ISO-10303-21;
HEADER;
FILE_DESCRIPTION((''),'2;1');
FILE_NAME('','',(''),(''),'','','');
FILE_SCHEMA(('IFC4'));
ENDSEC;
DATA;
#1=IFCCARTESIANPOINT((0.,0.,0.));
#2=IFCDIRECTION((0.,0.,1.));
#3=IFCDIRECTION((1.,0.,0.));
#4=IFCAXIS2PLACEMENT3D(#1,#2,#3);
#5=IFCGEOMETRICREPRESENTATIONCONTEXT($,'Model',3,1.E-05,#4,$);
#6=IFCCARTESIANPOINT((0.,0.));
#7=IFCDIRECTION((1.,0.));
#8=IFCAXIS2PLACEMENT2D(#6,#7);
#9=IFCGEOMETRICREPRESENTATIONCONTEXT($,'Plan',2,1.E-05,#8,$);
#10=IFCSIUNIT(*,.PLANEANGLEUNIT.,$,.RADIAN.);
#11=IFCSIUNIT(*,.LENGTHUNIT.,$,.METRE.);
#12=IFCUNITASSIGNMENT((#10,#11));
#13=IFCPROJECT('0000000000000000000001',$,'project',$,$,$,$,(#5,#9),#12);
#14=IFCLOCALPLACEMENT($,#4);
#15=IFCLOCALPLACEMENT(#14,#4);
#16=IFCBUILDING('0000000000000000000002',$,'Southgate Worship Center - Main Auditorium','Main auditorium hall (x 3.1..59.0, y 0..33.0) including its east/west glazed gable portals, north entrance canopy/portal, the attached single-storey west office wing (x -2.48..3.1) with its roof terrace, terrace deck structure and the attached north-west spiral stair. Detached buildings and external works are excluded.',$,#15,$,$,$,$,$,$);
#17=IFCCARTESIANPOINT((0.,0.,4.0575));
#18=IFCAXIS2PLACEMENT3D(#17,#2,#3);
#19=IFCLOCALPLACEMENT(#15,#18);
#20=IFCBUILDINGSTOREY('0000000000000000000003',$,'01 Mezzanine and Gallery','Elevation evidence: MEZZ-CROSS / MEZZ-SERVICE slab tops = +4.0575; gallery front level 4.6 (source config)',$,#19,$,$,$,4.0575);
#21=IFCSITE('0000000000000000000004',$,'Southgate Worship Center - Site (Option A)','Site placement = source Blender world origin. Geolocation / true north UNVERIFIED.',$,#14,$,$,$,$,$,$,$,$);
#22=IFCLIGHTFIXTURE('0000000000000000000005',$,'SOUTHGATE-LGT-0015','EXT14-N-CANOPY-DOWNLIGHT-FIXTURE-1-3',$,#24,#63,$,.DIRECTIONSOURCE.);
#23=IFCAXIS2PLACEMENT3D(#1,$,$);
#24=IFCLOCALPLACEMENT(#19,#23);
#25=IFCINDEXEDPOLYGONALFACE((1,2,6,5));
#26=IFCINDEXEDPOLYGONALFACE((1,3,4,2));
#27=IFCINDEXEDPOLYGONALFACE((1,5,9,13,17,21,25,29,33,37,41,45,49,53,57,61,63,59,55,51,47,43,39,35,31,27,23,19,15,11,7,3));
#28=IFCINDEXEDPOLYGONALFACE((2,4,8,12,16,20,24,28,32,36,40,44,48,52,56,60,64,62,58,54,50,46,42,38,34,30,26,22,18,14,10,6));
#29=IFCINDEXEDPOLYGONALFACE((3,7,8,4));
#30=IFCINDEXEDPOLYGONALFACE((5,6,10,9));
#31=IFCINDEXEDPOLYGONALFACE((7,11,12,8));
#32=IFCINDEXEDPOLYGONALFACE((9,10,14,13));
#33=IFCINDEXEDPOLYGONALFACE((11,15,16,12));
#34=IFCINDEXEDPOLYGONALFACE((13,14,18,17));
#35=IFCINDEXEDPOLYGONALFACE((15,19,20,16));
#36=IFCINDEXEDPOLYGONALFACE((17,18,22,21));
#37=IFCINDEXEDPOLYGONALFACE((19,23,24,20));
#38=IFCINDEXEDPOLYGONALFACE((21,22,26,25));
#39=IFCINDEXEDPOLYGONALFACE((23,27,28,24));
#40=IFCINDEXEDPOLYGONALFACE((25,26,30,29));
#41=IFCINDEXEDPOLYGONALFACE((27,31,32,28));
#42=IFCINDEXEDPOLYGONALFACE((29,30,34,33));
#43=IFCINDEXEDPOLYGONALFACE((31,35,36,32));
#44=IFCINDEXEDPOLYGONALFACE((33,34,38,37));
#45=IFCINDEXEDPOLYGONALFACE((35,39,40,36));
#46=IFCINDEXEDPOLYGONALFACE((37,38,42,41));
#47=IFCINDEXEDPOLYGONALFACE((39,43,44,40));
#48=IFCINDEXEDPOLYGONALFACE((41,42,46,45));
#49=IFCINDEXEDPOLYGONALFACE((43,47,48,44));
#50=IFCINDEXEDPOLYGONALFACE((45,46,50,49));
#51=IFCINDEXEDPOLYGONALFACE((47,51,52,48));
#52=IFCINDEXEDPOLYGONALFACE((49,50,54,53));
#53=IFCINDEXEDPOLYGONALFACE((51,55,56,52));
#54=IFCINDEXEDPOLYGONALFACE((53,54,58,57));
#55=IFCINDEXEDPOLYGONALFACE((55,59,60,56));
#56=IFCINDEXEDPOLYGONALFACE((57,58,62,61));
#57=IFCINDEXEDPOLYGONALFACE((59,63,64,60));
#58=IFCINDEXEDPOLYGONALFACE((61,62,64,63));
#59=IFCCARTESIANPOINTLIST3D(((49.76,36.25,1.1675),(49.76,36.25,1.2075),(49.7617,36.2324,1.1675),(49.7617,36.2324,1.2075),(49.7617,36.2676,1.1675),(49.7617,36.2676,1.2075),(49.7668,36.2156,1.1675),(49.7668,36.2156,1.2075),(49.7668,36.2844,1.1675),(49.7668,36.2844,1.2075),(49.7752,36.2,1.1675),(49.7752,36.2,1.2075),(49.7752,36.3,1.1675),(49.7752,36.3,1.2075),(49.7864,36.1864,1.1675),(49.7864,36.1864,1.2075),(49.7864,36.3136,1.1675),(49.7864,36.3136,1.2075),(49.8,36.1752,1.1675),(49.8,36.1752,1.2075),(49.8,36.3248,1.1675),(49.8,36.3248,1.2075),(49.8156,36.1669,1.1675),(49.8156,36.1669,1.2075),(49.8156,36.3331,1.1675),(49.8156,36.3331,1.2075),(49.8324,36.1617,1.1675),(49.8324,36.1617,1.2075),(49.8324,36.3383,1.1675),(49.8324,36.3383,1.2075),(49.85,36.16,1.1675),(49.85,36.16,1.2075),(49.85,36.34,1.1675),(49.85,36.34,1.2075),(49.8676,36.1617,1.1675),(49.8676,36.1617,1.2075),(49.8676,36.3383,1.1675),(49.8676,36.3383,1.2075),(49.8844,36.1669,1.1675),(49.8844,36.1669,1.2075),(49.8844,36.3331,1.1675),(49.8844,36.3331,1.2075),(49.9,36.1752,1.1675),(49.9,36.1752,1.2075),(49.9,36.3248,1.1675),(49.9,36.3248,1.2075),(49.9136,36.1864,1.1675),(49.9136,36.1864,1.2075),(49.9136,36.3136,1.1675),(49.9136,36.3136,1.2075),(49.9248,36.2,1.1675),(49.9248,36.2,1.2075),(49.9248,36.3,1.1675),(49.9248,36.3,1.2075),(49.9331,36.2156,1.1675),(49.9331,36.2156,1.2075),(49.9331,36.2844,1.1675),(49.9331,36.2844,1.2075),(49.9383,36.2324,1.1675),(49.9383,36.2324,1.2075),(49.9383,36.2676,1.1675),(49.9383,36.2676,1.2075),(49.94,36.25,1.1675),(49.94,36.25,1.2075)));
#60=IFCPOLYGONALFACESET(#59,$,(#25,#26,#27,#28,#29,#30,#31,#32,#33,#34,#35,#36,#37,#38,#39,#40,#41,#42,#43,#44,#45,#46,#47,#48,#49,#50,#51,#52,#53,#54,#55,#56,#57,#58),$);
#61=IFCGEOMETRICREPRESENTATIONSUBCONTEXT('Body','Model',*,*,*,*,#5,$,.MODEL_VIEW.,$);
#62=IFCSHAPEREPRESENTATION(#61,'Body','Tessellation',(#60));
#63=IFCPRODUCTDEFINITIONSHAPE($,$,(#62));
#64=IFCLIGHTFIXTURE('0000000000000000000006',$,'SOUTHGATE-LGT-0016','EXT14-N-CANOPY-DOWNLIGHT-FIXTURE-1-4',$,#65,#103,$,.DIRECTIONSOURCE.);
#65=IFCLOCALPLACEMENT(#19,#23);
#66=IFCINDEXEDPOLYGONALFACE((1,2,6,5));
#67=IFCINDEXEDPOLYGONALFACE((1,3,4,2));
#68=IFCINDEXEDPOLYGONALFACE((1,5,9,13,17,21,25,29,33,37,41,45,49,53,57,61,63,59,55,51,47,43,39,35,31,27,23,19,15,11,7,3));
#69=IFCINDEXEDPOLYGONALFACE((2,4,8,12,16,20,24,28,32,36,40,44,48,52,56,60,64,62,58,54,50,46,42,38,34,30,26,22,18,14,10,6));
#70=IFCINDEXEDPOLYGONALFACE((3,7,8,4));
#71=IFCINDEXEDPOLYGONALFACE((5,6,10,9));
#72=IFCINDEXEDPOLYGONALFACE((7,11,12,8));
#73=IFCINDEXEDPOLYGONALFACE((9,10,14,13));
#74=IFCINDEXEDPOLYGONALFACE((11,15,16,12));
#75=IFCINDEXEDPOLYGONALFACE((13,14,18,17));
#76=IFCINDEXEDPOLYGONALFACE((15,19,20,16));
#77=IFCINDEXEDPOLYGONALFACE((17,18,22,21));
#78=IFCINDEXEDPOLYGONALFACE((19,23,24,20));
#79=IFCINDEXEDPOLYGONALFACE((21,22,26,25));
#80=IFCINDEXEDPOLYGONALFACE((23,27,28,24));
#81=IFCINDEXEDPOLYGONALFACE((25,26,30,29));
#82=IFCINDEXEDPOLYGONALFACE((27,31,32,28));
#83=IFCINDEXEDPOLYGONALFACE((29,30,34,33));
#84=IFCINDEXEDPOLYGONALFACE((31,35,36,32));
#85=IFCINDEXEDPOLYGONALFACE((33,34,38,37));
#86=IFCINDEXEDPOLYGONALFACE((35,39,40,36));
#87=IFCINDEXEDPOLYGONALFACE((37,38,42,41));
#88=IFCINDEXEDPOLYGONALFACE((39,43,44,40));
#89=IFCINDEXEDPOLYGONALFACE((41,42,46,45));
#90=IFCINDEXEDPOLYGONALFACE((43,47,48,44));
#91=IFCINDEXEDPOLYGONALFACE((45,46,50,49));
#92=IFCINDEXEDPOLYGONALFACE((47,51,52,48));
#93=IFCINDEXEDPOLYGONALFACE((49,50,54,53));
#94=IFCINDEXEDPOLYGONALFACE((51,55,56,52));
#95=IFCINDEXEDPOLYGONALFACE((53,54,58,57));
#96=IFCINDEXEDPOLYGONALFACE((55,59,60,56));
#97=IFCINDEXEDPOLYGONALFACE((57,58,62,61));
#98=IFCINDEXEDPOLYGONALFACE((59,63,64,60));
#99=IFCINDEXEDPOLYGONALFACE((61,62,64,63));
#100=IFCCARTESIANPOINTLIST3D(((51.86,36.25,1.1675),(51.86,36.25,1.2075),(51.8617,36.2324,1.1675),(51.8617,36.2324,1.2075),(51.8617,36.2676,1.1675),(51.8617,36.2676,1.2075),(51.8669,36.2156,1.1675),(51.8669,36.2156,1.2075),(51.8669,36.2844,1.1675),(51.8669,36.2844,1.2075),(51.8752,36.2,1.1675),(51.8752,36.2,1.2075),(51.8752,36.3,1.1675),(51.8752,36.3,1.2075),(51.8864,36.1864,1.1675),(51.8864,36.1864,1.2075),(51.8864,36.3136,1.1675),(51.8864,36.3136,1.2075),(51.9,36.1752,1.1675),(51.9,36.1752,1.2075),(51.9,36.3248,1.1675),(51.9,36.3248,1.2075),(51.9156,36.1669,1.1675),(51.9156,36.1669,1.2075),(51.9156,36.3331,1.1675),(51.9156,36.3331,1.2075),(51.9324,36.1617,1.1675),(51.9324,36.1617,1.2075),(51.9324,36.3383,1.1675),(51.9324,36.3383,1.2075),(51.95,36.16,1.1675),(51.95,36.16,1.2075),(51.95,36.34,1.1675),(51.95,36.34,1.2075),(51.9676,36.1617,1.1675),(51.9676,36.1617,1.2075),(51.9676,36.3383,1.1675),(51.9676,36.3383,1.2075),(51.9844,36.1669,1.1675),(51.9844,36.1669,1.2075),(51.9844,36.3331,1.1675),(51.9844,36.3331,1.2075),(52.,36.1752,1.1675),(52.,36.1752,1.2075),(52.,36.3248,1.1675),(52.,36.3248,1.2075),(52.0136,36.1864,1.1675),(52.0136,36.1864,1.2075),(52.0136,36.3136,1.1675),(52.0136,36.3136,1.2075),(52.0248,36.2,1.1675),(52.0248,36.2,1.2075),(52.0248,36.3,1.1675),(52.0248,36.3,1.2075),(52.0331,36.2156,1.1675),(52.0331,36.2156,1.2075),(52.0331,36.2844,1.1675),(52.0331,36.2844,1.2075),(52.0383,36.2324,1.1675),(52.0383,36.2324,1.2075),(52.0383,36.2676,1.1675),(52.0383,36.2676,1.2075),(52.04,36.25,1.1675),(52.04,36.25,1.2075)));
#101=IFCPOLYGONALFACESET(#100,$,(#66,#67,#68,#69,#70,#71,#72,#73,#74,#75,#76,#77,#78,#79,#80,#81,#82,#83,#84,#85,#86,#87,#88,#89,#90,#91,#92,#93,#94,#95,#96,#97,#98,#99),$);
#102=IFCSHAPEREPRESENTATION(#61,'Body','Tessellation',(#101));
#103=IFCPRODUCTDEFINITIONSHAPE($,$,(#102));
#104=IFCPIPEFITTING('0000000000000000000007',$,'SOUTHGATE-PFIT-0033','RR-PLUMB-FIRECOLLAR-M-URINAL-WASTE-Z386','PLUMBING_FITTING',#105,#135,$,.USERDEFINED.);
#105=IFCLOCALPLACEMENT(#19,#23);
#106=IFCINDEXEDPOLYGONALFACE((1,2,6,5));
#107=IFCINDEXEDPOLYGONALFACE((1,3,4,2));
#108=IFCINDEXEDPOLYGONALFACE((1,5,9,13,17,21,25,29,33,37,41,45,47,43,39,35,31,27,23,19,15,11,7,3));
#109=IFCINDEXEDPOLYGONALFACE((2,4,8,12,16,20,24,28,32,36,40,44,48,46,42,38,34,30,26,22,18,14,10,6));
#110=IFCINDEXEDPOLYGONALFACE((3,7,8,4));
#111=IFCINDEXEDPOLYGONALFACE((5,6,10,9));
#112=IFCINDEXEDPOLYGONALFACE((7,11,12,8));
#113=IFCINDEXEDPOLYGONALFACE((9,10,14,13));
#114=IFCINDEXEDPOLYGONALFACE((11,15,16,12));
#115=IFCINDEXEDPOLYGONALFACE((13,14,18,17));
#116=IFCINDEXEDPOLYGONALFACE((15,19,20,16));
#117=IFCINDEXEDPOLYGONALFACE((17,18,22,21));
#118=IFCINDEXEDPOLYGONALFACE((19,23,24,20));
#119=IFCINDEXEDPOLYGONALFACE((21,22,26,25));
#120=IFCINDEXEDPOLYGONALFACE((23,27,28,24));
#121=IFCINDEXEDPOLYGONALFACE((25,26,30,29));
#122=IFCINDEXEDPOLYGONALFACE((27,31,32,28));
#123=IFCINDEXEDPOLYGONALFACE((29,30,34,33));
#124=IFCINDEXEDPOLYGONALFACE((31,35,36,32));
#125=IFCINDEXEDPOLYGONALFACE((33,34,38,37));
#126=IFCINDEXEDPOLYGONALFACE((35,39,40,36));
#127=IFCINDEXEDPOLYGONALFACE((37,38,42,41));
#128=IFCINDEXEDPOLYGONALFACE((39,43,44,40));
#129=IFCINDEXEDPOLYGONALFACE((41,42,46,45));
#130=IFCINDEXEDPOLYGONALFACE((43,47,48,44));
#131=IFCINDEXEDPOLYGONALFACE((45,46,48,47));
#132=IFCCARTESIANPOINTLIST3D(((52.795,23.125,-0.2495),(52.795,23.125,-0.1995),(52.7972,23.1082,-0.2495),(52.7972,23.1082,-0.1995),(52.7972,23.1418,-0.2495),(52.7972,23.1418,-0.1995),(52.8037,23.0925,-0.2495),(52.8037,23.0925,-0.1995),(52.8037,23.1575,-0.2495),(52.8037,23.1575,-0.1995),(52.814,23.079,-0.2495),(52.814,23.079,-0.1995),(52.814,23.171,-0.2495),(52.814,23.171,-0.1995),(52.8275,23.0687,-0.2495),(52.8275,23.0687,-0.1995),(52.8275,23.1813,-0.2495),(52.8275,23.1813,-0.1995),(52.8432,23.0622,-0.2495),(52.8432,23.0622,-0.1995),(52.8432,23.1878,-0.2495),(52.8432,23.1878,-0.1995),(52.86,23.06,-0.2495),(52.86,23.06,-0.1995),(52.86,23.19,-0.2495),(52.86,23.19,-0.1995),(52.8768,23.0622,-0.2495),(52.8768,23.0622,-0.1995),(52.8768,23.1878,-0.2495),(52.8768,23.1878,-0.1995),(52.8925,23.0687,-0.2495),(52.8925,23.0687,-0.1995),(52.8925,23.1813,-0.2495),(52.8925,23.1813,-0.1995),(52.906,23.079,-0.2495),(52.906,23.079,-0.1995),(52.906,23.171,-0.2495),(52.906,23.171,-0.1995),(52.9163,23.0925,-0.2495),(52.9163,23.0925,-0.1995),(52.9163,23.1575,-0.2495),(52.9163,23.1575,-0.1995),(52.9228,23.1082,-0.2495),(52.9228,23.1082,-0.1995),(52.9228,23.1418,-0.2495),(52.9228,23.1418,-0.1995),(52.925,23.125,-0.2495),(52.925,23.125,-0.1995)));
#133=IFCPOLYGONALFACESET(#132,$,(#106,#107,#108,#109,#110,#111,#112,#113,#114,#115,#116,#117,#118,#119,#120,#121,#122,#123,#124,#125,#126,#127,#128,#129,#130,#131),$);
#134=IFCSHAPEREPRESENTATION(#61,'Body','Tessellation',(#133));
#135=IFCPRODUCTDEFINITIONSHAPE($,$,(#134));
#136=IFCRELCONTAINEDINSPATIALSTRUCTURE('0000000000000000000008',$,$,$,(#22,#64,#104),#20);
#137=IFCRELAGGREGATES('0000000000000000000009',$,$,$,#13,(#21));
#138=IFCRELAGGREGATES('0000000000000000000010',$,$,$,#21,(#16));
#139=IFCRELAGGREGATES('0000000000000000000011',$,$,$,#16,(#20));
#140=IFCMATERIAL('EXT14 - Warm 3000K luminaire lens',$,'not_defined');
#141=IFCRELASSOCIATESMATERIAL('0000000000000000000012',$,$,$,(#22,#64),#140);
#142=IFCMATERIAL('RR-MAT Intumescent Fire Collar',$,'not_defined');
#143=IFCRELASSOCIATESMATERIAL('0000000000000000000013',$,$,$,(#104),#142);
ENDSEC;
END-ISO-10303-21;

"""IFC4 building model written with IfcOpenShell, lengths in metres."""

from ifc_helpers import new_model, si_unit, frame, origin_with_axes, origin_2d_with_axis, place, context, subcontext, project, spatial, indexed_curve, outline, extrude, material, element, save


model = new_model("IFC4")

# Units and contexts
model_context = context("Model", 3, precision=1e-05, world=origin_with_axes())
plan_context = context("Plan", 2, precision=1e-05, world=origin_2d_with_axis())
body_context = subcontext(model_context, "Body", "Model", "MODEL_VIEW")
ifc_project = project(units=[si_unit("PLANEANGLEUNIT", "RADIAN"), si_unit("LENGTHUNIT", "METRE")], contexts=[model_context, plan_context])

# Site, building, storey
site_placement = place(None, origin_with_axes())
site = spatial("IfcSite", under=ifc_project, at=site_placement, Name="Southgate Worship Center - Site (Option A)", Description="Site placement = source Blender world origin. Geolocation / true north UNVERIFIED.")
building_placement = place(site_placement, origin_with_axes())
building = spatial("IfcBuilding", under=site, at=building_placement, Name="Southgate Worship Center - Main Auditorium", Description="Main auditorium hall (x 3.1..59.0, y 0..33.0) including its east/west glazed gable portals, north entrance canopy/portal, the attached single-storey west office wing (x -2.48..3.1) with its roof terrace, terrace deck structure and the attached north-west spiral stair. Detached buildings and external works are excluded.")
storey_placement = place(building_placement, frame((0.0, 0.0, 4.0575), z_axis=(0.0, 0.0, 1.0), x_axis=(1.0, 0.0, 0.0)))
storey = spatial("IfcBuildingStorey", under=building, at=storey_placement, Name="01 Mezzanine and Gallery", Description="Elevation evidence: MEZZ-CROSS / MEZZ-SERVICE slab tops = +4.0575; gallery front level 4.6 (source config)", Elevation=4.0575)

# Light fixtures
ifc_material_1 = material(Name="EXT14 - Warm 3000K luminaire lens", Category="not_defined")
light_fixture_1_placement = place(storey_placement, frame((49.76, 36.16, 1.1675), z_axis=(0.0, 0.0, 1.0), x_axis=(1.0, 0.0, 0.0)))
element("IfcLightFixture", 1, at=light_fixture_1_placement, inside=storey, material=ifc_material_1, Name="SOUTHGATE-LGT-0015", Description="EXT14-N-CANOPY-DOWNLIGHT-FIXTURE-1-3", PredefinedType="DIRECTIONSOURCE", context=body_context, shape_type="SweptSolid", body=[
    extrude(outline(indexed_curve([(0.0, 0.0), (-0.0083, -0.0156), (-0.0134, -0.0324), (-0.0152, -0.05), (-0.0134, -0.0676), (-0.0083, -0.0844), (0.0, -0.1), (0.0112, -0.1136), (0.0248, -0.1248), (0.0404, -0.1332), (0.0573, -0.1383), (0.0748, -0.14), (0.0924, -0.1383), (0.1093, -0.1332), (0.1248, -0.1248), (0.1385, -0.1136), (0.1497, -0.1), (0.158, -0.0844), (0.1631, -0.0676), (0.1648, -0.05), (0.1631, -0.0324), (0.158, -0.0156), (0.1497, 0.0), (0.1385, 0.0136), (0.1248, 0.0248), (0.1093, 0.0331), (0.0924, 0.0383), (0.0748, 0.04), (0.0573, 0.0383), (0.0404, 0.0331), (0.0248, 0.0248), (0.0112, 0.0136), (0.0, 0.0)], self_intersect=False)), frame((0.0152, 0.14, 0.0), z_axis=(0.0, 0.0, 1.0), x_axis=(1.0, 0.0, 0.0)), (0.0, 0.0, 1.0), 0.04),
])
light_fixture_2_placement = place(storey_placement, frame((51.86, 36.16, 1.1675), z_axis=(0.0, 0.0, 1.0), x_axis=(1.0, 0.0, 0.0)))
element("IfcLightFixture", 2, at=light_fixture_2_placement, inside=storey, material=ifc_material_1, Name="SOUTHGATE-LGT-0016", Description="EXT14-N-CANOPY-DOWNLIGHT-FIXTURE-1-4", PredefinedType="DIRECTIONSOURCE", context=body_context, shape_type="SweptSolid", body=[
    extrude(outline(indexed_curve([(0.0, 0.0), (-0.0083, -0.0156), (-0.0134, -0.0324), (-0.0152, -0.05), (-0.0134, -0.0676), (-0.0083, -0.0844), (0.0, -0.1), (0.0112, -0.1136), (0.0248, -0.1248), (0.0404, -0.1332), (0.0573, -0.1383), (0.0748, -0.14), (0.0924, -0.1383), (0.1093, -0.1332), (0.1248, -0.1248), (0.1385, -0.1136), (0.1497, -0.1), (0.158, -0.0844), (0.1631, -0.0676), (0.1648, -0.05), (0.1631, -0.0324), (0.158, -0.0156), (0.1497, 0.0), (0.1385, 0.0136), (0.1248, 0.0248), (0.1093, 0.0331), (0.0924, 0.0383), (0.0748, 0.04), (0.0573, 0.0383), (0.0404, 0.0331), (0.0248, 0.0248), (0.0112, 0.0136), (0.0, 0.0)], self_intersect=False)), frame((0.0152, 0.14, 0.0), z_axis=(0.0, 0.0, 1.0), x_axis=(1.0, 0.0, 0.0)), (0.0, 0.0, 1.0), 0.04),
])

# Pipe fitting
ifc_material_2 = material(Name="RR-MAT Intumescent Fire Collar", Category="not_defined")
pipe_fitting_placement = place(storey_placement, frame((52.795, 23.06, -0.2495), z_axis=(0.0, 0.0, 1.0), x_axis=(1.0, 0.0, 0.0)))
element("IfcPipeFitting", 3, at=pipe_fitting_placement, inside=storey, material=ifc_material_2, Name="SOUTHGATE-PFIT-0033", Description="RR-PLUMB-FIRECOLLAR-M-URINAL-WASTE-Z386", ObjectType="PLUMBING_FITTING", PredefinedType="USERDEFINED", context=body_context, shape_type="SweptSolid", body=[
    extrude(outline(indexed_curve([(0.0, 0.0), (-0.0103, -0.0135), (-0.0168, -0.0291), (-0.019, -0.046), (-0.0168, -0.0628), (-0.0103, -0.0785), (0.0, -0.0919), (0.0135, -0.1023), (0.0291, -0.1087), (0.046, -0.111), (0.0628, -0.1087), (0.0785, -0.1023), (0.0919, -0.0919), (0.1023, -0.0785), (0.1087, -0.0628), (0.111, -0.046), (0.1087, -0.0291), (0.1023, -0.0135), (0.0919, 0.0), (0.0785, 0.0103), (0.0628, 0.0168), (0.046, 0.019), (0.0291, 0.0168), (0.0135, 0.0103), (0.0, 0.0)], self_intersect=False)), frame((0.019, 0.111, 0.0), z_axis=(0.0, 0.0, 1.0), x_axis=(1.0, 0.0, 0.0)), (0.0, 0.0, 1.0), 0.05),
])

save(model, "model.ifc")
